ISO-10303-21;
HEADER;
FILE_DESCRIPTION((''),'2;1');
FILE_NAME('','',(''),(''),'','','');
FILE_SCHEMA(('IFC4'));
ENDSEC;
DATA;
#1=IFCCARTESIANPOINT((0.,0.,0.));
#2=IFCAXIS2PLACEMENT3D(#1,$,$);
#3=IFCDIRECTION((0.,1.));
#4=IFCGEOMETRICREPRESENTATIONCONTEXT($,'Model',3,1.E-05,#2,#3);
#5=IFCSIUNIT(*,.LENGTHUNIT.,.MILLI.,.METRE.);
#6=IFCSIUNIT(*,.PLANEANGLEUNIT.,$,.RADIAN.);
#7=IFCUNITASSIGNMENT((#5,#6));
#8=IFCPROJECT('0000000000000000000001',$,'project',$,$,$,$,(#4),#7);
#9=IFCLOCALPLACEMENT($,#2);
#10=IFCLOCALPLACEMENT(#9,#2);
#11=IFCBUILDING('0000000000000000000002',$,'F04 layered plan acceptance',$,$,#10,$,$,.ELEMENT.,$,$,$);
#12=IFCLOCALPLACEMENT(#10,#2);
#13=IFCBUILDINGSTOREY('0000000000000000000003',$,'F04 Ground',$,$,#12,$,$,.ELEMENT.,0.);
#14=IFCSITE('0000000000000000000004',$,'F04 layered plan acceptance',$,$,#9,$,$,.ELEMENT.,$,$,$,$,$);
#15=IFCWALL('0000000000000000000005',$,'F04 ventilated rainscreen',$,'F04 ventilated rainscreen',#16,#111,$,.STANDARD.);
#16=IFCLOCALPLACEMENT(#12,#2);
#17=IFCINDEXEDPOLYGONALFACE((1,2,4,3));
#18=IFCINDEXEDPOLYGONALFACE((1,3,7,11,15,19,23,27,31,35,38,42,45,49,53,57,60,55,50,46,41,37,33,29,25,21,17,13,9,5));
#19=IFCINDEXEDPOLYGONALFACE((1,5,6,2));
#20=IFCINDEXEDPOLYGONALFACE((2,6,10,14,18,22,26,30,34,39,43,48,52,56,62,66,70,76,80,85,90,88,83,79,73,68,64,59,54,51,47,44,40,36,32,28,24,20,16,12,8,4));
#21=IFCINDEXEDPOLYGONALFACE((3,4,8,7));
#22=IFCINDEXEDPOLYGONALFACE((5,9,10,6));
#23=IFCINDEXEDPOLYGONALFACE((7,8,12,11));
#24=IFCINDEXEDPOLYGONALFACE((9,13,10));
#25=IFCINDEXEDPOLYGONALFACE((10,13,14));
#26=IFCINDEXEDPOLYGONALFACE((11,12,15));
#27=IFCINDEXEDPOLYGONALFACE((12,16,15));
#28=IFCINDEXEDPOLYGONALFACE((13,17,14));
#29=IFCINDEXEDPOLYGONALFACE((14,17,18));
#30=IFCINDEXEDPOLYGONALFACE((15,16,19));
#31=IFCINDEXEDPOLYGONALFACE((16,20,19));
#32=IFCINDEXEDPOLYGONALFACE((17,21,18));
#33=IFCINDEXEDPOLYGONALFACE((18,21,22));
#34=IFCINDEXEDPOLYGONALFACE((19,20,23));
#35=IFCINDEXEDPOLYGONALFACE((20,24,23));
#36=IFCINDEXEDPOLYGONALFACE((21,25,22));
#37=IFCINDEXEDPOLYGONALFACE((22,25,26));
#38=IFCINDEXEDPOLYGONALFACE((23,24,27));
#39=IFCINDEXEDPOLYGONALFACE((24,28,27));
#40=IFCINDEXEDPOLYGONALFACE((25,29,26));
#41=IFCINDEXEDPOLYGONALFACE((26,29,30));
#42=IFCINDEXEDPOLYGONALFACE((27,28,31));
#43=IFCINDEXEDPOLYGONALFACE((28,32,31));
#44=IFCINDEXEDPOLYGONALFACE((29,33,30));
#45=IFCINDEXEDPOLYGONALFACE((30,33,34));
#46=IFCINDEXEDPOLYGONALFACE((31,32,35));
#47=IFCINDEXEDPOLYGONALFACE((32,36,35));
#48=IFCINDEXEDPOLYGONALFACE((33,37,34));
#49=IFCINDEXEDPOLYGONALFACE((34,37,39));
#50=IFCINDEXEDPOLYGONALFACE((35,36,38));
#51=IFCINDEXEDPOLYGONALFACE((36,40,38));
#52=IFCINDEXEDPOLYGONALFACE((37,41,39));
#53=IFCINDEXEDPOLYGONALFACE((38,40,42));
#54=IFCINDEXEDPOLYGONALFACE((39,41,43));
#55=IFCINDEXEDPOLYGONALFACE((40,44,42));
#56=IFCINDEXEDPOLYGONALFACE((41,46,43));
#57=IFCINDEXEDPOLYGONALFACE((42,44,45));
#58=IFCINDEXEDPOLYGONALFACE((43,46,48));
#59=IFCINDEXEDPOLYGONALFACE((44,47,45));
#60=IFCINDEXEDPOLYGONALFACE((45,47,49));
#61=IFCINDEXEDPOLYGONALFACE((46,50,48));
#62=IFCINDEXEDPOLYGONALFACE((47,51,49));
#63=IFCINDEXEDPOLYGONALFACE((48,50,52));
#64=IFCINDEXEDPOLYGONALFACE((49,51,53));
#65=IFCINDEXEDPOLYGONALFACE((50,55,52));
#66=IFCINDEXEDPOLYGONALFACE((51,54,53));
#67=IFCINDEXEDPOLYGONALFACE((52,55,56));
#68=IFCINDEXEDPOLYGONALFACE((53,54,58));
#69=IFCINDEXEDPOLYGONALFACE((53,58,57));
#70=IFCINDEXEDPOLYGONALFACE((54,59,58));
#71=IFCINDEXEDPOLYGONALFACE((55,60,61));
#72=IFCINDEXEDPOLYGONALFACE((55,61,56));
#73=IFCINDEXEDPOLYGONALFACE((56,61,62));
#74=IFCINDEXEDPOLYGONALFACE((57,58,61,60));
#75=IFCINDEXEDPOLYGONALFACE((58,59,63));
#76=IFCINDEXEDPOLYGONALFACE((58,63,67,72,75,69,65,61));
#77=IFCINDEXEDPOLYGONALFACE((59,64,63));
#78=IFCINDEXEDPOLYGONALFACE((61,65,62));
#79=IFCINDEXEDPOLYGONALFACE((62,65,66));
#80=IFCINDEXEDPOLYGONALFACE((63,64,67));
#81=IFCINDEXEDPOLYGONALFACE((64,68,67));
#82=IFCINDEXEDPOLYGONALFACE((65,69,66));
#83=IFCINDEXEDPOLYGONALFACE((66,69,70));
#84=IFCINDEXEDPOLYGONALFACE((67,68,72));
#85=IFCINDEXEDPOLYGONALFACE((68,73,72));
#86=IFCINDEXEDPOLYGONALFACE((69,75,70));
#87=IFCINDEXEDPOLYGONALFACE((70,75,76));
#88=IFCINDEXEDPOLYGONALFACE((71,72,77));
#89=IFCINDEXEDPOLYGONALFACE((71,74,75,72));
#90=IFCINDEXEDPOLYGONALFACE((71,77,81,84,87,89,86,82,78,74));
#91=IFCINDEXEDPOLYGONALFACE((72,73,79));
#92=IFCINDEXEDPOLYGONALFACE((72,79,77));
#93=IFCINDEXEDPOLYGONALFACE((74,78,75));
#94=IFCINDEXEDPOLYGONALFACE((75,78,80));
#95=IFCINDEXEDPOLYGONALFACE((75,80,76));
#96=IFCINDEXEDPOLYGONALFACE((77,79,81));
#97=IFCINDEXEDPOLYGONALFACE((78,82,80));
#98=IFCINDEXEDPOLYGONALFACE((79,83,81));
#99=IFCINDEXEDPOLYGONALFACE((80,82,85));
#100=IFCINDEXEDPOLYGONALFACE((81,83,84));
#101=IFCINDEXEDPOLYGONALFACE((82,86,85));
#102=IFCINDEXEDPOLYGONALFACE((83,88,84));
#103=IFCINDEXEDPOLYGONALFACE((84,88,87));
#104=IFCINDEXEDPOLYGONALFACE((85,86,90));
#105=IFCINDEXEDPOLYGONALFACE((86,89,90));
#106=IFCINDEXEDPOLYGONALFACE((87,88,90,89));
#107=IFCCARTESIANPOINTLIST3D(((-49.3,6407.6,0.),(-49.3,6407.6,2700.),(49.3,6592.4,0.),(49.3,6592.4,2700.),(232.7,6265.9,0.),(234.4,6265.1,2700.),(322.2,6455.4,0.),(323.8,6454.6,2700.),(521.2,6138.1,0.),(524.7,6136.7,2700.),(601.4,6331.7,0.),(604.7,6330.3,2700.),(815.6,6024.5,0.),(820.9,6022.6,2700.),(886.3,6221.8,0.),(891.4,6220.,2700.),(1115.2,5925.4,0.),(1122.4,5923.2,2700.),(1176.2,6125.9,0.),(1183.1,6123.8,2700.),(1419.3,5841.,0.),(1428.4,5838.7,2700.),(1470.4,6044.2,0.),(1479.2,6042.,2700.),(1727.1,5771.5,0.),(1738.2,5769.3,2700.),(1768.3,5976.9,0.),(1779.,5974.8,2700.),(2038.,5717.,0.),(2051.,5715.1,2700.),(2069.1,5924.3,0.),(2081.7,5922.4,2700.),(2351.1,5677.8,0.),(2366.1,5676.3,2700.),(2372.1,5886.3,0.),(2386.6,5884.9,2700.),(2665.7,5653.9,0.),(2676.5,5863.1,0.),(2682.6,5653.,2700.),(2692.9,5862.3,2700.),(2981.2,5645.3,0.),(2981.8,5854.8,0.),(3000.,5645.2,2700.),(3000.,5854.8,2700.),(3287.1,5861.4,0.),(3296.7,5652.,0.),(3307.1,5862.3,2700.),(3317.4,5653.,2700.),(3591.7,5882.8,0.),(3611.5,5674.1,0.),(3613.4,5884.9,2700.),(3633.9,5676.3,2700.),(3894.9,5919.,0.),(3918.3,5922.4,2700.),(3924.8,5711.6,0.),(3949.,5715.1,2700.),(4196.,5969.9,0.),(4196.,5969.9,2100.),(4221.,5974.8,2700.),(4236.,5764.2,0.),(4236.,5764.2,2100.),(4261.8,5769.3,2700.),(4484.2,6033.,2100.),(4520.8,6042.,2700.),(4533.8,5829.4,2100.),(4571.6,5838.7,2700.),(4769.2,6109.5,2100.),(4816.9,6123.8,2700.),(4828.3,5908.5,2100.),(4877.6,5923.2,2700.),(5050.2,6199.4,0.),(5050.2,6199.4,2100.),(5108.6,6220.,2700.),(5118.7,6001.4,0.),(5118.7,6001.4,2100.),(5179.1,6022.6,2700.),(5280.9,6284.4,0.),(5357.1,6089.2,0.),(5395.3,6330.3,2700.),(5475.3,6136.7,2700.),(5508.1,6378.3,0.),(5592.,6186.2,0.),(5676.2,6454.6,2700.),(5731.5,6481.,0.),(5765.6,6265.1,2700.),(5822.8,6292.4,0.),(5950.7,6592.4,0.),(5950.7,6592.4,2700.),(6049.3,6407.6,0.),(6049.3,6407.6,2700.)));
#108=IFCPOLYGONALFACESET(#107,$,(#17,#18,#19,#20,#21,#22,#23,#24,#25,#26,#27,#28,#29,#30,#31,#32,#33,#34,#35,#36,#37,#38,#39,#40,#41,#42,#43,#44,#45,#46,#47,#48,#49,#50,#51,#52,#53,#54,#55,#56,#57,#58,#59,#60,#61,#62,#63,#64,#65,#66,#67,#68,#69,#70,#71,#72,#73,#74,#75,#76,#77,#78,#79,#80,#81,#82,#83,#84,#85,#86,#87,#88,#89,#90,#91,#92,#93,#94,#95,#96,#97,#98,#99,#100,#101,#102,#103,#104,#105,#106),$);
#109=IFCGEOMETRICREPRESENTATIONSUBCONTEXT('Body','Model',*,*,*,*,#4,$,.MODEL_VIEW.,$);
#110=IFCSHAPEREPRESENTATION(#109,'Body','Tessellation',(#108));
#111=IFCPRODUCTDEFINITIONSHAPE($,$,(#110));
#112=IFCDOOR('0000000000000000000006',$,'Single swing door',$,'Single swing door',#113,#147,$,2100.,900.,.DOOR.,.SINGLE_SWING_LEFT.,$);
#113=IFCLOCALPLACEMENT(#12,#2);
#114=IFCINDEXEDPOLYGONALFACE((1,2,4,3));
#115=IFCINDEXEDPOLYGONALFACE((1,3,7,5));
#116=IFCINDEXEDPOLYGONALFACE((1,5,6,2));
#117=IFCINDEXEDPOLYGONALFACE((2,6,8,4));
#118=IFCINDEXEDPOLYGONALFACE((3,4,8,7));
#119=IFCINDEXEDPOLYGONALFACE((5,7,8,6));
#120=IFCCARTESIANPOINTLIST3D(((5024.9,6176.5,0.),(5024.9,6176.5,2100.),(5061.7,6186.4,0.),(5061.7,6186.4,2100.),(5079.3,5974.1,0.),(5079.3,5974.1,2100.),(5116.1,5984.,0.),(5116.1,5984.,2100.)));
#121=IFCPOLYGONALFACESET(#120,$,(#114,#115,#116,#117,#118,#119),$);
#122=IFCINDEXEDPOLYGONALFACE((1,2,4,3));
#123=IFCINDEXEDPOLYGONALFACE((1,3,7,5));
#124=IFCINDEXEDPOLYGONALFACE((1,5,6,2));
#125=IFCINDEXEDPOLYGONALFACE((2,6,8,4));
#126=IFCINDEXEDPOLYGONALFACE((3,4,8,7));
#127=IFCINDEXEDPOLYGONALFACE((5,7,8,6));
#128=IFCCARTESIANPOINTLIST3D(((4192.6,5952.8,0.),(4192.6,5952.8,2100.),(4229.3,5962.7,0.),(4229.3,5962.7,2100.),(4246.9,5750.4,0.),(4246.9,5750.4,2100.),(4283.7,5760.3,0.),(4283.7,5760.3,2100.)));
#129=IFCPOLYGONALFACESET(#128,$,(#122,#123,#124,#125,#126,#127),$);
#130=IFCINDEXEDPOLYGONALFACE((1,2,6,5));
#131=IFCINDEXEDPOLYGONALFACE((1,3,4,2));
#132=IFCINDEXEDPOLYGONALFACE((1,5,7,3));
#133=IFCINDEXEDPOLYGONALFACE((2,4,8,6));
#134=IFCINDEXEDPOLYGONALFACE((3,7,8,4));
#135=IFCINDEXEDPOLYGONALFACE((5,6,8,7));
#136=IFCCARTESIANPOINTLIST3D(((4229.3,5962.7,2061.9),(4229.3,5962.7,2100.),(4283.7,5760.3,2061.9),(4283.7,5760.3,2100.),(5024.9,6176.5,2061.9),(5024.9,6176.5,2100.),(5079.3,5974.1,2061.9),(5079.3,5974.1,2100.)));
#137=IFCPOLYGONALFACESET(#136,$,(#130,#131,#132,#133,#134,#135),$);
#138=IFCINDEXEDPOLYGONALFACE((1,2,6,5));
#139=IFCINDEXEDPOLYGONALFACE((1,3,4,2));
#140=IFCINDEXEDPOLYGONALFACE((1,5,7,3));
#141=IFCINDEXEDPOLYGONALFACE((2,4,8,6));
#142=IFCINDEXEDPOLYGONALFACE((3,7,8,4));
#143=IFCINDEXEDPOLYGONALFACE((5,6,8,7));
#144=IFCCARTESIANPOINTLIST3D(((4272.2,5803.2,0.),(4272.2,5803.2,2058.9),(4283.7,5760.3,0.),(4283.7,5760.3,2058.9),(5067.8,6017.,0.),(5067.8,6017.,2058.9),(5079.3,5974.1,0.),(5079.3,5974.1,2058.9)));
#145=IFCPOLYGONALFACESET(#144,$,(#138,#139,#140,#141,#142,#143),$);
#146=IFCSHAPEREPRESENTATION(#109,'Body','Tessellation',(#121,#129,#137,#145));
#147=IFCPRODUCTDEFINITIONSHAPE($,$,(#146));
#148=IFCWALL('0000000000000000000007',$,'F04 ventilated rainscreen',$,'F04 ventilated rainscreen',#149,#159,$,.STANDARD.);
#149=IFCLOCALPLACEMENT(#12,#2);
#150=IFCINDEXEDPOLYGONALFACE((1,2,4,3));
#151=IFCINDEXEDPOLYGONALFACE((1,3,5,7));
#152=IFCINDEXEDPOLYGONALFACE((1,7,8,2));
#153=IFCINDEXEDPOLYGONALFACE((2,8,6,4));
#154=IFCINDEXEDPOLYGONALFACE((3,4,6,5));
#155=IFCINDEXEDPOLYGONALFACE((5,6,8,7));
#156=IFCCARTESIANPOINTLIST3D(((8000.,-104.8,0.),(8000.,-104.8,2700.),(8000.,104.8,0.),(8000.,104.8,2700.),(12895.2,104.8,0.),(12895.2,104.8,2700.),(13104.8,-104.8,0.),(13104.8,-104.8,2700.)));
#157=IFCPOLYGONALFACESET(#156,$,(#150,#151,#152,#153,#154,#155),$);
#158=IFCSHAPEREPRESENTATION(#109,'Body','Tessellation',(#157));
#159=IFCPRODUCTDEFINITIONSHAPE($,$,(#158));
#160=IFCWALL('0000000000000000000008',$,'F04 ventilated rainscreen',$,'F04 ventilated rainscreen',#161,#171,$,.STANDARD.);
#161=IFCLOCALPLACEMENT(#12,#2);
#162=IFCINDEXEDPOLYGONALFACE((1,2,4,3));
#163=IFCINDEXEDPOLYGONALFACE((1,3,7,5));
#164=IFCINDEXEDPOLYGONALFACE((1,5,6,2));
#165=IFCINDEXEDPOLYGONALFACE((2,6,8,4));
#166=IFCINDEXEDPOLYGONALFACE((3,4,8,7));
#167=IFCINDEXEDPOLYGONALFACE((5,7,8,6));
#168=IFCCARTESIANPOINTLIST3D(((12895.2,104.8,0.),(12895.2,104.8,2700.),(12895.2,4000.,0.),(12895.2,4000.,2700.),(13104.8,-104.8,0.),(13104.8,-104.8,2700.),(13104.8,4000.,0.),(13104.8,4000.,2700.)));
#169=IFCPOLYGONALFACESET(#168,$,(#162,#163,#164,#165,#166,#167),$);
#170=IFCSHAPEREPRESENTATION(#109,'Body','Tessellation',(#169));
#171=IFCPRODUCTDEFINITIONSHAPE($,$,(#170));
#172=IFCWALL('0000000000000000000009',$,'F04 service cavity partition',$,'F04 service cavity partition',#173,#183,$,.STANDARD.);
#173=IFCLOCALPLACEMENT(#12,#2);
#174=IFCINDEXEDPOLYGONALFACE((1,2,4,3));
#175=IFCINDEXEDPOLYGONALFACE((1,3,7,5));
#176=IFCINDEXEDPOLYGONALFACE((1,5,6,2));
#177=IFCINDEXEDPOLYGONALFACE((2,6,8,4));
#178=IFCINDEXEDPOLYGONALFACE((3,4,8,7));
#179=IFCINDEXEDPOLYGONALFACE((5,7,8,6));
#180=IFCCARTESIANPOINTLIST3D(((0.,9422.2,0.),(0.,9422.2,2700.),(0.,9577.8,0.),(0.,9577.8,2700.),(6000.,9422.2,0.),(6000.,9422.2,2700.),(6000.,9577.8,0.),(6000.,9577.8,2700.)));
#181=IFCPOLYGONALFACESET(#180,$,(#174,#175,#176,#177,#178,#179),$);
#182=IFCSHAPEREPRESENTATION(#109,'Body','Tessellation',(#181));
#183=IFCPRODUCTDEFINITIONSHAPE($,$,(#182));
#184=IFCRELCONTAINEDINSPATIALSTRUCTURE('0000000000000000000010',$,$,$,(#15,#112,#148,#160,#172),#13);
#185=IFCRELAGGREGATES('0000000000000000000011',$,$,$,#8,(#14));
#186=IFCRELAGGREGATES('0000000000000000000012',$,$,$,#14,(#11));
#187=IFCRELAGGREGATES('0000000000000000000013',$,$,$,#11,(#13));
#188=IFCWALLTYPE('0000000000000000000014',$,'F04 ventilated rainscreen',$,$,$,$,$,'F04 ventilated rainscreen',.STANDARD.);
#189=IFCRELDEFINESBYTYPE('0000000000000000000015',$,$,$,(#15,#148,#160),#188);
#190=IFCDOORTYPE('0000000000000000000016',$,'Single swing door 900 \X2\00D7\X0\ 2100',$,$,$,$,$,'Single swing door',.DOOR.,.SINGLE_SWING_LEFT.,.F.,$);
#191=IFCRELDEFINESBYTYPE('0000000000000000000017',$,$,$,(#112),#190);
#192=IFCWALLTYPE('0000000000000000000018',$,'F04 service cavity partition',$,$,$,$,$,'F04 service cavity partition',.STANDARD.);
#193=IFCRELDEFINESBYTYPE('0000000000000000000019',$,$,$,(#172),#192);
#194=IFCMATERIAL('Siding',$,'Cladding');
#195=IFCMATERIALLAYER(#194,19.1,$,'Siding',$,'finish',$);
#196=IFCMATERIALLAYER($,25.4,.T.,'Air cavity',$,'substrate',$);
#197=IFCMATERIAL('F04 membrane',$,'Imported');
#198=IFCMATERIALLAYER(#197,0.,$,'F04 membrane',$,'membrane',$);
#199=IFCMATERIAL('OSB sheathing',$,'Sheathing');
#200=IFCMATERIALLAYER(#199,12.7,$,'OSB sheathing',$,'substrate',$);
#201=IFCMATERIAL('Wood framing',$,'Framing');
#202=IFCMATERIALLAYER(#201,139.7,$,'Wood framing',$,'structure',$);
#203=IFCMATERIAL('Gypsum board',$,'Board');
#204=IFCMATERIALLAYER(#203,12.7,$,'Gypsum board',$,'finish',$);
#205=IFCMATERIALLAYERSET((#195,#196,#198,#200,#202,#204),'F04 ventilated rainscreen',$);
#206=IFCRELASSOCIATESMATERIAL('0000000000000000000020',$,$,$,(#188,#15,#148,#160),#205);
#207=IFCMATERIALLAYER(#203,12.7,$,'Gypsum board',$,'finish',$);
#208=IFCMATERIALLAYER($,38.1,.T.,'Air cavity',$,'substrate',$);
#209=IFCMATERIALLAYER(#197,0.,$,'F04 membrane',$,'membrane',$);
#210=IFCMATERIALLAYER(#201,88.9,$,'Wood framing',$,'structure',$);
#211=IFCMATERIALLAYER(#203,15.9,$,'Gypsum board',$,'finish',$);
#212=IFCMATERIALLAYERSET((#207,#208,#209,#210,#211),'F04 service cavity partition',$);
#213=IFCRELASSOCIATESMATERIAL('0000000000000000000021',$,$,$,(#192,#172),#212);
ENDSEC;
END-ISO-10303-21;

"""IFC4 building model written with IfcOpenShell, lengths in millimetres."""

from ifc_helpers import new_model, si_unit, direction, frame, origin, origin_with_axes, place, context, subcontext, project, spatial, polyline, line, arc, indexed_curve, outline, extrude, material, layer, layer_set, layer_usage, type_object, element, fill, save


model = new_model("IFC4")

# Units and contexts
model_context = context("Model", 3, precision=1e-05, world=origin(), true_north=direction((0.0, 1.0)))
body_context = subcontext(model_context, "Body", "Model", "MODEL_VIEW")
ifc_project = project(units=[si_unit("LENGTHUNIT", "METRE", prefix="MILLI"), si_unit("PLANEANGLEUNIT", "RADIAN")], contexts=[model_context])

# Site, building, storey
site_placement = place(None, origin())
site = spatial("IfcSite", under=ifc_project, at=site_placement, Name="F04 layered plan acceptance", CompositionType="ELEMENT")
building_placement = place(site_placement, origin())
building = spatial("IfcBuilding", under=site, at=building_placement, Name="F04 layered plan acceptance", CompositionType="ELEMENT")
storey_placement = place(building_placement, origin())
storey = spatial("IfcBuildingStorey", under=building, at=storey_placement, Name="F04 Ground", CompositionType="ELEMENT", Elevation=0.0)

# Shared definitions
ifc_material_1 = material(Name="Siding", Category="Cladding")
ifc_layer_1 = layer(ifc_material_1, 19.1, Name="Siding", Category="finish")
ifc_layer_2 = layer(None, 25.4, ventilated=True, Name="Air cavity", Category="substrate")
ifc_material_2 = material(Name="F04 membrane", Category="Imported")
ifc_layer_3 = layer(ifc_material_2, 0.0, Name="F04 membrane", Category="membrane")
ifc_material_3 = material(Name="OSB sheathing", Category="Sheathing")
ifc_layer_4 = layer(ifc_material_3, 12.7, Name="OSB sheathing", Category="substrate")
ifc_material_4 = material(Name="Wood framing", Category="Framing")
ifc_layer_5 = layer(ifc_material_4, 139.7, Name="Wood framing", Category="structure")
ifc_material_5 = material(Name="Gypsum board", Category="Board")
ifc_layer_6 = layer(ifc_material_5, 12.7, Name="Gypsum board", Category="finish")
ifc_layer_set_1 = layer_set([ifc_layer_1, ifc_layer_2, ifc_layer_3, ifc_layer_4, ifc_layer_5, ifc_layer_6], Name="F04 ventilated rainscreen")
wall_type_1 = type_object("IfcWallType", Name="F04 ventilated rainscreen", ElementType="F04 ventilated rainscreen", PredefinedType="STANDARD", material=ifc_layer_set_1)
door_type = type_object("IfcDoorType", Name="Single swing door 900 × 2100", ElementType="Single swing door", OperationType="SINGLE_SWING_LEFT", ParameterTakesPrecedence=False, PredefinedType="DOOR")

# Wall, opening, door
ifc_layer_usage_1 = layer_usage(ifc_layer_set_1, "AXIS2", "POSITIVE", -104.8)
wall_1_placement = place(storey_placement, frame((6000.0, 6500.0, 0.0), z_axis=(0.0, 0.0, 1.0), x_axis=(-1.0, 0.0, 0.0)))
wall_1 = element("IfcWall", 1, at=wall_1_placement, inside=storey, type_object=wall_type_1, material=ifc_layer_usage_1, Name="F04 ventilated rainscreen", ObjectType="F04 ventilated rainscreen", PredefinedType="STANDARD", context=body_context, shape_type="SweptSolid", body=[
    extrude(outline(indexed_curve([(49.3, -92.4), (3000.0, 645.2), (5950.7, -92.4), (6049.3, 92.4), (3000.0, 854.8), (-49.3, 92.4)], segments=[arc(1, 2, 3), line(3, 4), arc(4, 5, 6), line(6, 1)], self_intersect=False)), origin(), (0.0, 0.0, 1.0), 2700.0),
])
opening_1_placement = place(wall_1_placement, frame((911.1, 414.8, 0.0), z_axis=(0.0, 0.0, 1.0), x_axis=(0.965743, 0.259502, 0.0)))
opening_1 = element("IfcOpeningElement", 2, at=opening_1_placement, cuts=wall_1, PredefinedType="OPENING", context=body_context, shape_type="SweptSolid", body=[
    extrude(outline(polyline([(8.5, -130.4), (891.5, -130.4), (908.9, 114.8), (-8.9, 114.8), (8.5, -130.4)])), origin(), (0.0, 0.0, 1.0), 2100.0),
])
door_1_placement = place(opening_1_placement, origin_with_axes())
door_1 = element("IfcDoor", 3, at=door_1_placement, inside=storey, type_object=door_type, Name="Single swing door", ObjectType="Single swing door", OperationType="SINGLE_SWING_LEFT", OverallHeight=2100.0, OverallWidth=900.0, PredefinedType="DOOR", context=body_context, shape_type="SweptSolid", body=[
    extrude(outline(polyline([(0.0, -104.8), (38.1, -104.8), (38.1, 104.8), (0.0, 104.8), (0.0, -104.8)])), origin(), (0.0, 0.0, 1.0), 2100.0),
    extrude(outline(polyline([(861.9, -104.8), (900.0, -104.8), (900.0, 104.8), (861.9, 104.8), (861.9, -104.8)])), origin(), (0.0, 0.0, 1.0), 2100.0),
    extrude(outline(polyline([(38.1, -104.8), (861.9, -104.8), (861.9, 104.8), (38.1, 104.8), (38.1, -104.8)])), frame((0.0, 0.0, 2061.9)), (0.0, 0.0, 1.0), 38.1),
    extrude(outline(polyline([(38.1, 60.3), (861.9, 60.3), (861.9, 104.8), (38.1, 104.8), (38.1, 60.3)])), origin(), (0.0, 0.0, 1.0), 2058.9),
])
fill(opening_1, door_1)

# Walls
ifc_layer_usage_2 = layer_usage(ifc_layer_set_1, "AXIS2", "NEGATIVE", 104.8)
wall_2_placement = place(storey_placement, frame((8000.0, 0.0, 0.0), z_axis=(0.0, 0.0, 1.0), x_axis=(1.0, 0.0, 0.0)))
element("IfcWall", 4, at=wall_2_placement, inside=storey, type_object=wall_type_1, material=ifc_layer_usage_2, Name="F04 ventilated rainscreen", ObjectType="F04 ventilated rainscreen", PredefinedType="STANDARD", context=body_context, shape_type="SweptSolid", body=[
    extrude(outline(polyline([(0.0, -104.8), (5104.8, -104.8), (4895.2, 104.8), (0.0, 104.8), (0.0, -104.8)])), origin(), (0.0, 0.0, 1.0), 2700.0),
])
ifc_layer_usage_3 = layer_usage(ifc_layer_set_1, "AXIS2", "NEGATIVE", 104.8)
wall_3_placement = place(storey_placement, frame((13000.0, 0.0, 0.0), z_axis=(0.0, 0.0, 1.0), x_axis=(0.0, 1.0, 0.0)))
element("IfcWall", 5, at=wall_3_placement, inside=storey, type_object=wall_type_1, material=ifc_layer_usage_3, Name="F04 ventilated rainscreen", ObjectType="F04 ventilated rainscreen", PredefinedType="STANDARD", context=body_context, shape_type="SweptSolid", body=[
    extrude(outline(polyline([(-104.8, -104.8), (4000.0, -104.8), (4000.0, 104.8), (104.8, 104.8), (-104.8, -104.8)])), origin(), (0.0, 0.0, 1.0), 2700.0),
])

# Wall
ifc_layer_7 = layer(ifc_material_5, 12.7, Name="Gypsum board", Category="finish")
ifc_layer_8 = layer(None, 38.1, ventilated=True, Name="Air cavity", Category="substrate")
ifc_layer_9 = layer(ifc_material_2, 0.0, Name="F04 membrane", Category="membrane")
ifc_layer_10 = layer(ifc_material_4, 88.9, Name="Wood framing", Category="structure")
ifc_layer_11 = layer(ifc_material_5, 15.9, Name="Gypsum board", Category="finish")
ifc_layer_set_2 = layer_set([ifc_layer_7, ifc_layer_8, ifc_layer_9, ifc_layer_10, ifc_layer_11], Name="F04 service cavity partition")
wall_type_2 = type_object("IfcWallType", Name="F04 service cavity partition", ElementType="F04 service cavity partition", PredefinedType="STANDARD", material=ifc_layer_set_2)
ifc_layer_usage_4 = layer_usage(ifc_layer_set_2, "AXIS2", "NEGATIVE", 77.8)
wall_4_placement = place(storey_placement, frame((0.0, 9500.0, 0.0), z_axis=(0.0, 0.0, 1.0), x_axis=(1.0, 0.0, 0.0)))
element("IfcWall", 6, at=wall_4_placement, inside=storey, type_object=wall_type_2, material=ifc_layer_usage_4, Name="F04 service cavity partition", ObjectType="F04 service cavity partition", PredefinedType="STANDARD", context=body_context, shape_type="SweptSolid", body=[
    extrude(outline(polyline([(0.0, -77.8), (6000.0, -77.8), (6000.0, 77.8), (0.0, 77.8), (0.0, -77.8)])), origin(), (0.0, 0.0, 1.0), 2700.0),
])

save(model, "model.ifc")
